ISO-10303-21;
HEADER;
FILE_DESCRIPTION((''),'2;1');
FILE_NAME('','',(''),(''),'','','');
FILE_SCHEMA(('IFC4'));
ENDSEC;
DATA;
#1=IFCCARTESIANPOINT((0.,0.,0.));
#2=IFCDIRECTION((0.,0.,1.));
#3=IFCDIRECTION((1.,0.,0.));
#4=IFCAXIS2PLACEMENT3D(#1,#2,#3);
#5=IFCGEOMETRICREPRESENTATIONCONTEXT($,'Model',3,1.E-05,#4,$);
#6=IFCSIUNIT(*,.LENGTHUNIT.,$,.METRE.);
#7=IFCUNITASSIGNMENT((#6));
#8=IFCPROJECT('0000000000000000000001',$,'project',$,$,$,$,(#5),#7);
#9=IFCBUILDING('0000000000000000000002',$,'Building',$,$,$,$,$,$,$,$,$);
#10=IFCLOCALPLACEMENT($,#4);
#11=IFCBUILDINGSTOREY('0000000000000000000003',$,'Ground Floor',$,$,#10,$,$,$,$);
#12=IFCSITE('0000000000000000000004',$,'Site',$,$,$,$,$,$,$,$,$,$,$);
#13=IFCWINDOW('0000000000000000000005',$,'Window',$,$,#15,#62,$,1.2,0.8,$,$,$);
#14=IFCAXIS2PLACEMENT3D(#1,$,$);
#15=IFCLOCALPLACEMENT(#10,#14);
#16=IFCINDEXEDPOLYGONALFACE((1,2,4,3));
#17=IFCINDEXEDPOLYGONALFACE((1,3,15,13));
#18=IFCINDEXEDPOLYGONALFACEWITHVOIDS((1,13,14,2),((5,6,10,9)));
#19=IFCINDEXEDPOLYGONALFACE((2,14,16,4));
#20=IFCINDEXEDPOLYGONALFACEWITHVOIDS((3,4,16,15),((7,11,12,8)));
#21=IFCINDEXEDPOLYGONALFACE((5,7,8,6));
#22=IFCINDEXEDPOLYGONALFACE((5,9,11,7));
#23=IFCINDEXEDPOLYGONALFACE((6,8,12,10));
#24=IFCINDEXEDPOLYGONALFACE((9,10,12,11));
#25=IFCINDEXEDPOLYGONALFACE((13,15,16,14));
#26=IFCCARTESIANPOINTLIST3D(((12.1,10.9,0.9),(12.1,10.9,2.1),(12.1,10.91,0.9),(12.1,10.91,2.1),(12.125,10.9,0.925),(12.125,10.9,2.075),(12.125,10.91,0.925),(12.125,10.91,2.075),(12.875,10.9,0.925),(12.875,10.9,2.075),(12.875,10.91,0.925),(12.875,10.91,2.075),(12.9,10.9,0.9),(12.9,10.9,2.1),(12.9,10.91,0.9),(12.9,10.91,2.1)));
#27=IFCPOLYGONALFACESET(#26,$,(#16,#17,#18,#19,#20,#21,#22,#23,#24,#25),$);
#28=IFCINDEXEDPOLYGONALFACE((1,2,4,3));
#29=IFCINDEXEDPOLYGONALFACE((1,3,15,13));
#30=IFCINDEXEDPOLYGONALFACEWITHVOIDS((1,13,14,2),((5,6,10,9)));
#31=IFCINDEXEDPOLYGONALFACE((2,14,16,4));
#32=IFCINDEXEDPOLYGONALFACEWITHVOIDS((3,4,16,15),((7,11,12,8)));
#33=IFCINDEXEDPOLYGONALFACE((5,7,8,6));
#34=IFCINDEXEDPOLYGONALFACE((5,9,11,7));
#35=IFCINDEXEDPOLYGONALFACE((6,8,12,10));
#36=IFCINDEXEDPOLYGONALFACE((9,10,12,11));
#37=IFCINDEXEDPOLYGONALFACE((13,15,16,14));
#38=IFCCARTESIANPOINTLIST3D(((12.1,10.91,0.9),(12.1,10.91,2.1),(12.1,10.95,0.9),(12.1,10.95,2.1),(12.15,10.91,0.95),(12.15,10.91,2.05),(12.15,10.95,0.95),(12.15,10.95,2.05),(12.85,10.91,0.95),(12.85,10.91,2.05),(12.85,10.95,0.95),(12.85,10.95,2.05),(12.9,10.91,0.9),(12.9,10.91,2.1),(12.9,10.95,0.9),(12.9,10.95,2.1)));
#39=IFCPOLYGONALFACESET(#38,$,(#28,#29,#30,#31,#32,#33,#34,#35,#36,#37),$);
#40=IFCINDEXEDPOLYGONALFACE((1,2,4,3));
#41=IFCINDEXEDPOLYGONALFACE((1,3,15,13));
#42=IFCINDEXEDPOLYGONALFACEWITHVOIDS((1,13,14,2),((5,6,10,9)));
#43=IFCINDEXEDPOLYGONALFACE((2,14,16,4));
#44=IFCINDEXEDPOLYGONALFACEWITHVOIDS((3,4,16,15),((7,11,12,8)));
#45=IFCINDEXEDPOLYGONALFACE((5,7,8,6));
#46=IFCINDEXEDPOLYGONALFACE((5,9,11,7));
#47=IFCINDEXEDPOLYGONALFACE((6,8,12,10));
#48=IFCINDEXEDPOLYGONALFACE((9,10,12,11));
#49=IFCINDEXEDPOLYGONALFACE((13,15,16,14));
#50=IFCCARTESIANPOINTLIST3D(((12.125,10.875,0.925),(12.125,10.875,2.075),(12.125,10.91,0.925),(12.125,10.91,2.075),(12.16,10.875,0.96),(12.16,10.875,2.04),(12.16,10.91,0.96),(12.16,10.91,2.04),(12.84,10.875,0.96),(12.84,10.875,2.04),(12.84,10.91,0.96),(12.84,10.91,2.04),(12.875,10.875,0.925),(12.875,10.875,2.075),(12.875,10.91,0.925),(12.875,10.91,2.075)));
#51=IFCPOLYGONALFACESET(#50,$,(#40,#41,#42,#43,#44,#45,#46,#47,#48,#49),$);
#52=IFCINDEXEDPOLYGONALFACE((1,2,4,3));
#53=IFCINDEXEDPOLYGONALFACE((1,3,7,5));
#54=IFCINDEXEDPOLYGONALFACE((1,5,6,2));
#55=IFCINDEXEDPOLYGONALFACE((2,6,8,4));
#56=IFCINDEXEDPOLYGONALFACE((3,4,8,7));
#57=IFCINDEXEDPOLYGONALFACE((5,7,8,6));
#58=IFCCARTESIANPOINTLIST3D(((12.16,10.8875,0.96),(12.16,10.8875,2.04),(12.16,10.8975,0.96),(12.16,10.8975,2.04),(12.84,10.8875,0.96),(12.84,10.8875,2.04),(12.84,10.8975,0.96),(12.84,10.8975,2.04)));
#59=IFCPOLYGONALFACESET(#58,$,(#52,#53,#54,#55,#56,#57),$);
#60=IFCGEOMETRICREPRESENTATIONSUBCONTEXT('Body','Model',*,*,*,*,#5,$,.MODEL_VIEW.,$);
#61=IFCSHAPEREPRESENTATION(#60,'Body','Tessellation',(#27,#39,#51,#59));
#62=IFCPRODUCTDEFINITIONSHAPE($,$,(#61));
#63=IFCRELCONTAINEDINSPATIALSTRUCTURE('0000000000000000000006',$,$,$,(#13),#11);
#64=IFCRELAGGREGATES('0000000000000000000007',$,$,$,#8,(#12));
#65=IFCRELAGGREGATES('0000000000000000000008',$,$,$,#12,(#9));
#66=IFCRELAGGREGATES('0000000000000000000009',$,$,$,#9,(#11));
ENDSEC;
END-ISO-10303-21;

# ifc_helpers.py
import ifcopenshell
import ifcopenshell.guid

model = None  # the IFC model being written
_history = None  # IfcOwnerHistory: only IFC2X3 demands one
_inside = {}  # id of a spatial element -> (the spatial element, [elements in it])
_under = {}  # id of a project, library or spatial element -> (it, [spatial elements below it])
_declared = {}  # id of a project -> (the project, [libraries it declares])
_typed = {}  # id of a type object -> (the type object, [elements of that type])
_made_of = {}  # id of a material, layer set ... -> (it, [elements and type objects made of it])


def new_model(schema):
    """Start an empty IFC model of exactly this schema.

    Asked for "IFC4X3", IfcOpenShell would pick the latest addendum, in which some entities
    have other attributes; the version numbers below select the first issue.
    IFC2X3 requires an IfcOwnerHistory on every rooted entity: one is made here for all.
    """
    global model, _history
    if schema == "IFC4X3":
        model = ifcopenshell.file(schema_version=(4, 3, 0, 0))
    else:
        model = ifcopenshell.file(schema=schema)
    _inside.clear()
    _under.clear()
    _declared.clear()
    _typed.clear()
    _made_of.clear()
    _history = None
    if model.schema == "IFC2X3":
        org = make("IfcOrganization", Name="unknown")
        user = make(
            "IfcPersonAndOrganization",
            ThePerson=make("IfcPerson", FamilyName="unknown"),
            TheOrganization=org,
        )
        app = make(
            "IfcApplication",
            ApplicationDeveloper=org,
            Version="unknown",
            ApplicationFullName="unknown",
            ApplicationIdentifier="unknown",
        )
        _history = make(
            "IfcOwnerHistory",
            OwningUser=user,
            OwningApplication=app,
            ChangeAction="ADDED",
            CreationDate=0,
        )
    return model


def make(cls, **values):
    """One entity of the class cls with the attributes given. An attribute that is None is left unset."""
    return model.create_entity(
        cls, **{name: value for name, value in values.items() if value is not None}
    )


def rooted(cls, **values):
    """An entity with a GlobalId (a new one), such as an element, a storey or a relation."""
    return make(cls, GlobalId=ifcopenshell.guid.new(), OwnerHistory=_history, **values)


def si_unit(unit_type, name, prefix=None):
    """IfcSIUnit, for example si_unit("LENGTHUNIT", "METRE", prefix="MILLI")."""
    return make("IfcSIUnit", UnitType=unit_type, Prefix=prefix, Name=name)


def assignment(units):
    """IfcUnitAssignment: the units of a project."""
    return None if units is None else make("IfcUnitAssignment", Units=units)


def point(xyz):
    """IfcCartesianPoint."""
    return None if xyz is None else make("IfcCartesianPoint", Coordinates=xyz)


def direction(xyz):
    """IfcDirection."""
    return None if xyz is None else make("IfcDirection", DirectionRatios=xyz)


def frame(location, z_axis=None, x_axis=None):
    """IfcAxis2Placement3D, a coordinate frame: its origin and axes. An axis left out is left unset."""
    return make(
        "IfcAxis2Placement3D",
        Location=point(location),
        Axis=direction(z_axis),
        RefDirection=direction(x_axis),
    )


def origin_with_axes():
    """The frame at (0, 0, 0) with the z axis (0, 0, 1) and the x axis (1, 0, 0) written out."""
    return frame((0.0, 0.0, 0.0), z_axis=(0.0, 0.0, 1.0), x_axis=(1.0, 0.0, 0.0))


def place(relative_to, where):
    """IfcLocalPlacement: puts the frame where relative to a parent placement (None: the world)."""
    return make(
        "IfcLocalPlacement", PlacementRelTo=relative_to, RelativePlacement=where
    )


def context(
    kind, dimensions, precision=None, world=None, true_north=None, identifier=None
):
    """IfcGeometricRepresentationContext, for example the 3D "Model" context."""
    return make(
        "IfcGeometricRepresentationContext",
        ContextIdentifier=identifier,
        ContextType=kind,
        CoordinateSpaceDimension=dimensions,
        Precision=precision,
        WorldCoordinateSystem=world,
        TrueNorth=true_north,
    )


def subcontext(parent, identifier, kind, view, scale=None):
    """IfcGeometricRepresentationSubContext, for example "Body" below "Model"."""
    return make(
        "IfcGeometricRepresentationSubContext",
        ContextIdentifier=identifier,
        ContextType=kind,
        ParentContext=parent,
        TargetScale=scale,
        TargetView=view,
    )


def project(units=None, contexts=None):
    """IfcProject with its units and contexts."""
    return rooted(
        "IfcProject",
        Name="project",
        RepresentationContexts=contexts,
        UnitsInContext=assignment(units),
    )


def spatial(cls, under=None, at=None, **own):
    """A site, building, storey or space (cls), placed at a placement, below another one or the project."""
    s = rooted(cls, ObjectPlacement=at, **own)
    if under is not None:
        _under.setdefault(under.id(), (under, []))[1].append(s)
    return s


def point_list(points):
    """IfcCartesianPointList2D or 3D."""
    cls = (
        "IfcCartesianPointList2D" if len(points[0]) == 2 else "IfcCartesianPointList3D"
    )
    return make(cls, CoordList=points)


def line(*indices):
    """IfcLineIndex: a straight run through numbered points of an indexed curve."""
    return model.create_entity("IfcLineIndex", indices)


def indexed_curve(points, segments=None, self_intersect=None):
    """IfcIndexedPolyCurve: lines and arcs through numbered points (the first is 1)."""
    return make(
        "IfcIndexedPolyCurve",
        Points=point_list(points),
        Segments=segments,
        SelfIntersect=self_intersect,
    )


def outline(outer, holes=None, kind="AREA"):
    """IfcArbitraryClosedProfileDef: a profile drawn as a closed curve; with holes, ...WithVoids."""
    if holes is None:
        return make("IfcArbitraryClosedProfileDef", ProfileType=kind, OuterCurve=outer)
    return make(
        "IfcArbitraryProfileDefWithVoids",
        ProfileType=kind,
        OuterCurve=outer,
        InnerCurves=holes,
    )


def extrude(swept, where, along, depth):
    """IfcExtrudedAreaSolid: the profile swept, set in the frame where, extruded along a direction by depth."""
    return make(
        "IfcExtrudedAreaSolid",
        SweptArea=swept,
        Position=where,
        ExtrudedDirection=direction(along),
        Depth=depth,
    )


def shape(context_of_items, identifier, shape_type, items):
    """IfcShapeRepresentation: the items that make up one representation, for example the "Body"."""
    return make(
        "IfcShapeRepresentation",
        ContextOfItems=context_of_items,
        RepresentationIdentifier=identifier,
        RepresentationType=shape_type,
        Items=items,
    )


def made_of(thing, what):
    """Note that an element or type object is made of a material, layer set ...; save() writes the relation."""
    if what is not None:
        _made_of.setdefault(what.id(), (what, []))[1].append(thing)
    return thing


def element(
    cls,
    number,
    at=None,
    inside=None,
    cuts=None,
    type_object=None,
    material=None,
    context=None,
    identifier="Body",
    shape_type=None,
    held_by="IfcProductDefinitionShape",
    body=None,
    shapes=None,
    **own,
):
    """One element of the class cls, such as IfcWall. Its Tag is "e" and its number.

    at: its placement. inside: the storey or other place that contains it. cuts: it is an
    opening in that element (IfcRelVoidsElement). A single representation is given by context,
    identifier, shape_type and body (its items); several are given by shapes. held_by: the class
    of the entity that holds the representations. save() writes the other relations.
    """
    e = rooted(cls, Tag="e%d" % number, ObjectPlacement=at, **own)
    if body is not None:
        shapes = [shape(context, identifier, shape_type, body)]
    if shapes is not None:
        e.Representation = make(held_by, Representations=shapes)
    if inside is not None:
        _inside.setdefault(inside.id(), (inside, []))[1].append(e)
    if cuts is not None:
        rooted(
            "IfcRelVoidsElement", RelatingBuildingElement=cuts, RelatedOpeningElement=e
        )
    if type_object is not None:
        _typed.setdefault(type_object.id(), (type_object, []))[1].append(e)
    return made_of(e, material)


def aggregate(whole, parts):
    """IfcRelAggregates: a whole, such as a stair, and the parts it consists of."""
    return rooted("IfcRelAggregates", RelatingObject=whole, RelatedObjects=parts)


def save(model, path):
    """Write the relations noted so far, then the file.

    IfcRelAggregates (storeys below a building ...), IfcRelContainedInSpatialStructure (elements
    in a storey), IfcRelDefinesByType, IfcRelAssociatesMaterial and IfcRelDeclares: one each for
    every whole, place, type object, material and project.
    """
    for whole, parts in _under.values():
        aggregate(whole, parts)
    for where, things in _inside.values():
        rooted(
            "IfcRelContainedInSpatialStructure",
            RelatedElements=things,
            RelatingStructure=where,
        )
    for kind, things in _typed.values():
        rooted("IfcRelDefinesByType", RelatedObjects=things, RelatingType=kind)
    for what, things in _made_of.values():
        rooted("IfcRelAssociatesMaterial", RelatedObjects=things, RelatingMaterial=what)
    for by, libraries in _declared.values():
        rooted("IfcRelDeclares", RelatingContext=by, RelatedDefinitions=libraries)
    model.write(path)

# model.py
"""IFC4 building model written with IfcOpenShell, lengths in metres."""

from ifc_helpers import new_model, si_unit, frame, origin_with_axes, place, context, subcontext, project, spatial, line, indexed_curve, outline, extrude, element, save


model = new_model("IFC4")

# Units and contexts
model_context = context("Model", 3, precision=1e-05, world=origin_with_axes())
body_context = subcontext(model_context, "Body", "Model", "MODEL_VIEW")
ifc_project = project(units=[si_unit("LENGTHUNIT", "METRE")], contexts=[model_context])

# Site, building, storey
site = spatial("IfcSite", under=ifc_project, Name="Site")
building = spatial("IfcBuilding", under=site, Name="Building")
storey_placement = place(None, origin_with_axes())
storey = spatial("IfcBuildingStorey", under=building, at=storey_placement, Name="Ground Floor")

# Window
window_1_placement = place(storey_placement, frame((12.9, 11.0, 0.9), z_axis=(0.0, 0.0, 1.0), x_axis=(-1.0, 0.0, 0.0)))
element("IfcWindow", 1, at=window_1_placement, inside=storey, Name="Window", OverallHeight=1.2, OverallWidth=0.8, context=body_context, shape_type="SweptSolid", body=[
    extrude(outline(indexed_curve([(0.0, 0.0), (0.8, 0.0), (0.8, 1.2), (0.0, 1.2)], segments=[line(1, 2, 3, 4, 1)]), holes=[indexed_curve([(0.025, 0.025), (0.775, 0.025), (0.775, 1.175), (0.025, 1.175)], segments=[line(1, 2, 3, 4, 1)])]), frame((0.0, 0.09, 0.0), z_axis=(0.0, -1.0, 0.0), x_axis=(1.0, 0.0, 0.0)), (0.0, 0.0, -1.0), 0.01),
    extrude(outline(indexed_curve([(0.0, 0.0), (0.8, 0.0), (0.8, 1.2), (0.0, 1.2)], segments=[line(1, 2, 3, 4, 1)]), holes=[indexed_curve([(0.05, 0.05), (0.75, 0.05), (0.75, 1.15), (0.05, 1.15)], segments=[line(1, 2, 3, 4, 1)])]), frame((0.0, 0.05, 0.0), z_axis=(0.0, -1.0, 0.0), x_axis=(1.0, 0.0, 0.0)), (0.0, 0.0, -1.0), 0.04),
    extrude(outline(indexed_curve([(0.0, 0.0), (0.75, 0.0), (0.75, 1.15), (0.0, 1.15)], segments=[line(1, 2, 3, 4, 1)]), holes=[indexed_curve([(0.035, 0.035), (0.715, 0.035), (0.715, 1.115), (0.035, 1.115)], segments=[line(1, 2, 3, 4, 1)])]), frame((0.025, 0.09, 0.025), z_axis=(0.0, -1.0, 0.0), x_axis=(1.0, 0.0, 0.0)), (0.0, 0.0, -1.0), 0.035),
    extrude(outline(indexed_curve([(0.035, 0.035), (0.715, 0.035), (0.715, 1.115), (0.035, 1.115)], segments=[line(1, 2, 3, 4, 1)])), frame((0.025, 0.1025, 0.025), z_axis=(0.0, -1.0, 0.0), x_axis=(1.0, 0.0, 0.0)), (0.0, 0.0, -1.0), 0.01),
])

save(model, "model.ifc")
